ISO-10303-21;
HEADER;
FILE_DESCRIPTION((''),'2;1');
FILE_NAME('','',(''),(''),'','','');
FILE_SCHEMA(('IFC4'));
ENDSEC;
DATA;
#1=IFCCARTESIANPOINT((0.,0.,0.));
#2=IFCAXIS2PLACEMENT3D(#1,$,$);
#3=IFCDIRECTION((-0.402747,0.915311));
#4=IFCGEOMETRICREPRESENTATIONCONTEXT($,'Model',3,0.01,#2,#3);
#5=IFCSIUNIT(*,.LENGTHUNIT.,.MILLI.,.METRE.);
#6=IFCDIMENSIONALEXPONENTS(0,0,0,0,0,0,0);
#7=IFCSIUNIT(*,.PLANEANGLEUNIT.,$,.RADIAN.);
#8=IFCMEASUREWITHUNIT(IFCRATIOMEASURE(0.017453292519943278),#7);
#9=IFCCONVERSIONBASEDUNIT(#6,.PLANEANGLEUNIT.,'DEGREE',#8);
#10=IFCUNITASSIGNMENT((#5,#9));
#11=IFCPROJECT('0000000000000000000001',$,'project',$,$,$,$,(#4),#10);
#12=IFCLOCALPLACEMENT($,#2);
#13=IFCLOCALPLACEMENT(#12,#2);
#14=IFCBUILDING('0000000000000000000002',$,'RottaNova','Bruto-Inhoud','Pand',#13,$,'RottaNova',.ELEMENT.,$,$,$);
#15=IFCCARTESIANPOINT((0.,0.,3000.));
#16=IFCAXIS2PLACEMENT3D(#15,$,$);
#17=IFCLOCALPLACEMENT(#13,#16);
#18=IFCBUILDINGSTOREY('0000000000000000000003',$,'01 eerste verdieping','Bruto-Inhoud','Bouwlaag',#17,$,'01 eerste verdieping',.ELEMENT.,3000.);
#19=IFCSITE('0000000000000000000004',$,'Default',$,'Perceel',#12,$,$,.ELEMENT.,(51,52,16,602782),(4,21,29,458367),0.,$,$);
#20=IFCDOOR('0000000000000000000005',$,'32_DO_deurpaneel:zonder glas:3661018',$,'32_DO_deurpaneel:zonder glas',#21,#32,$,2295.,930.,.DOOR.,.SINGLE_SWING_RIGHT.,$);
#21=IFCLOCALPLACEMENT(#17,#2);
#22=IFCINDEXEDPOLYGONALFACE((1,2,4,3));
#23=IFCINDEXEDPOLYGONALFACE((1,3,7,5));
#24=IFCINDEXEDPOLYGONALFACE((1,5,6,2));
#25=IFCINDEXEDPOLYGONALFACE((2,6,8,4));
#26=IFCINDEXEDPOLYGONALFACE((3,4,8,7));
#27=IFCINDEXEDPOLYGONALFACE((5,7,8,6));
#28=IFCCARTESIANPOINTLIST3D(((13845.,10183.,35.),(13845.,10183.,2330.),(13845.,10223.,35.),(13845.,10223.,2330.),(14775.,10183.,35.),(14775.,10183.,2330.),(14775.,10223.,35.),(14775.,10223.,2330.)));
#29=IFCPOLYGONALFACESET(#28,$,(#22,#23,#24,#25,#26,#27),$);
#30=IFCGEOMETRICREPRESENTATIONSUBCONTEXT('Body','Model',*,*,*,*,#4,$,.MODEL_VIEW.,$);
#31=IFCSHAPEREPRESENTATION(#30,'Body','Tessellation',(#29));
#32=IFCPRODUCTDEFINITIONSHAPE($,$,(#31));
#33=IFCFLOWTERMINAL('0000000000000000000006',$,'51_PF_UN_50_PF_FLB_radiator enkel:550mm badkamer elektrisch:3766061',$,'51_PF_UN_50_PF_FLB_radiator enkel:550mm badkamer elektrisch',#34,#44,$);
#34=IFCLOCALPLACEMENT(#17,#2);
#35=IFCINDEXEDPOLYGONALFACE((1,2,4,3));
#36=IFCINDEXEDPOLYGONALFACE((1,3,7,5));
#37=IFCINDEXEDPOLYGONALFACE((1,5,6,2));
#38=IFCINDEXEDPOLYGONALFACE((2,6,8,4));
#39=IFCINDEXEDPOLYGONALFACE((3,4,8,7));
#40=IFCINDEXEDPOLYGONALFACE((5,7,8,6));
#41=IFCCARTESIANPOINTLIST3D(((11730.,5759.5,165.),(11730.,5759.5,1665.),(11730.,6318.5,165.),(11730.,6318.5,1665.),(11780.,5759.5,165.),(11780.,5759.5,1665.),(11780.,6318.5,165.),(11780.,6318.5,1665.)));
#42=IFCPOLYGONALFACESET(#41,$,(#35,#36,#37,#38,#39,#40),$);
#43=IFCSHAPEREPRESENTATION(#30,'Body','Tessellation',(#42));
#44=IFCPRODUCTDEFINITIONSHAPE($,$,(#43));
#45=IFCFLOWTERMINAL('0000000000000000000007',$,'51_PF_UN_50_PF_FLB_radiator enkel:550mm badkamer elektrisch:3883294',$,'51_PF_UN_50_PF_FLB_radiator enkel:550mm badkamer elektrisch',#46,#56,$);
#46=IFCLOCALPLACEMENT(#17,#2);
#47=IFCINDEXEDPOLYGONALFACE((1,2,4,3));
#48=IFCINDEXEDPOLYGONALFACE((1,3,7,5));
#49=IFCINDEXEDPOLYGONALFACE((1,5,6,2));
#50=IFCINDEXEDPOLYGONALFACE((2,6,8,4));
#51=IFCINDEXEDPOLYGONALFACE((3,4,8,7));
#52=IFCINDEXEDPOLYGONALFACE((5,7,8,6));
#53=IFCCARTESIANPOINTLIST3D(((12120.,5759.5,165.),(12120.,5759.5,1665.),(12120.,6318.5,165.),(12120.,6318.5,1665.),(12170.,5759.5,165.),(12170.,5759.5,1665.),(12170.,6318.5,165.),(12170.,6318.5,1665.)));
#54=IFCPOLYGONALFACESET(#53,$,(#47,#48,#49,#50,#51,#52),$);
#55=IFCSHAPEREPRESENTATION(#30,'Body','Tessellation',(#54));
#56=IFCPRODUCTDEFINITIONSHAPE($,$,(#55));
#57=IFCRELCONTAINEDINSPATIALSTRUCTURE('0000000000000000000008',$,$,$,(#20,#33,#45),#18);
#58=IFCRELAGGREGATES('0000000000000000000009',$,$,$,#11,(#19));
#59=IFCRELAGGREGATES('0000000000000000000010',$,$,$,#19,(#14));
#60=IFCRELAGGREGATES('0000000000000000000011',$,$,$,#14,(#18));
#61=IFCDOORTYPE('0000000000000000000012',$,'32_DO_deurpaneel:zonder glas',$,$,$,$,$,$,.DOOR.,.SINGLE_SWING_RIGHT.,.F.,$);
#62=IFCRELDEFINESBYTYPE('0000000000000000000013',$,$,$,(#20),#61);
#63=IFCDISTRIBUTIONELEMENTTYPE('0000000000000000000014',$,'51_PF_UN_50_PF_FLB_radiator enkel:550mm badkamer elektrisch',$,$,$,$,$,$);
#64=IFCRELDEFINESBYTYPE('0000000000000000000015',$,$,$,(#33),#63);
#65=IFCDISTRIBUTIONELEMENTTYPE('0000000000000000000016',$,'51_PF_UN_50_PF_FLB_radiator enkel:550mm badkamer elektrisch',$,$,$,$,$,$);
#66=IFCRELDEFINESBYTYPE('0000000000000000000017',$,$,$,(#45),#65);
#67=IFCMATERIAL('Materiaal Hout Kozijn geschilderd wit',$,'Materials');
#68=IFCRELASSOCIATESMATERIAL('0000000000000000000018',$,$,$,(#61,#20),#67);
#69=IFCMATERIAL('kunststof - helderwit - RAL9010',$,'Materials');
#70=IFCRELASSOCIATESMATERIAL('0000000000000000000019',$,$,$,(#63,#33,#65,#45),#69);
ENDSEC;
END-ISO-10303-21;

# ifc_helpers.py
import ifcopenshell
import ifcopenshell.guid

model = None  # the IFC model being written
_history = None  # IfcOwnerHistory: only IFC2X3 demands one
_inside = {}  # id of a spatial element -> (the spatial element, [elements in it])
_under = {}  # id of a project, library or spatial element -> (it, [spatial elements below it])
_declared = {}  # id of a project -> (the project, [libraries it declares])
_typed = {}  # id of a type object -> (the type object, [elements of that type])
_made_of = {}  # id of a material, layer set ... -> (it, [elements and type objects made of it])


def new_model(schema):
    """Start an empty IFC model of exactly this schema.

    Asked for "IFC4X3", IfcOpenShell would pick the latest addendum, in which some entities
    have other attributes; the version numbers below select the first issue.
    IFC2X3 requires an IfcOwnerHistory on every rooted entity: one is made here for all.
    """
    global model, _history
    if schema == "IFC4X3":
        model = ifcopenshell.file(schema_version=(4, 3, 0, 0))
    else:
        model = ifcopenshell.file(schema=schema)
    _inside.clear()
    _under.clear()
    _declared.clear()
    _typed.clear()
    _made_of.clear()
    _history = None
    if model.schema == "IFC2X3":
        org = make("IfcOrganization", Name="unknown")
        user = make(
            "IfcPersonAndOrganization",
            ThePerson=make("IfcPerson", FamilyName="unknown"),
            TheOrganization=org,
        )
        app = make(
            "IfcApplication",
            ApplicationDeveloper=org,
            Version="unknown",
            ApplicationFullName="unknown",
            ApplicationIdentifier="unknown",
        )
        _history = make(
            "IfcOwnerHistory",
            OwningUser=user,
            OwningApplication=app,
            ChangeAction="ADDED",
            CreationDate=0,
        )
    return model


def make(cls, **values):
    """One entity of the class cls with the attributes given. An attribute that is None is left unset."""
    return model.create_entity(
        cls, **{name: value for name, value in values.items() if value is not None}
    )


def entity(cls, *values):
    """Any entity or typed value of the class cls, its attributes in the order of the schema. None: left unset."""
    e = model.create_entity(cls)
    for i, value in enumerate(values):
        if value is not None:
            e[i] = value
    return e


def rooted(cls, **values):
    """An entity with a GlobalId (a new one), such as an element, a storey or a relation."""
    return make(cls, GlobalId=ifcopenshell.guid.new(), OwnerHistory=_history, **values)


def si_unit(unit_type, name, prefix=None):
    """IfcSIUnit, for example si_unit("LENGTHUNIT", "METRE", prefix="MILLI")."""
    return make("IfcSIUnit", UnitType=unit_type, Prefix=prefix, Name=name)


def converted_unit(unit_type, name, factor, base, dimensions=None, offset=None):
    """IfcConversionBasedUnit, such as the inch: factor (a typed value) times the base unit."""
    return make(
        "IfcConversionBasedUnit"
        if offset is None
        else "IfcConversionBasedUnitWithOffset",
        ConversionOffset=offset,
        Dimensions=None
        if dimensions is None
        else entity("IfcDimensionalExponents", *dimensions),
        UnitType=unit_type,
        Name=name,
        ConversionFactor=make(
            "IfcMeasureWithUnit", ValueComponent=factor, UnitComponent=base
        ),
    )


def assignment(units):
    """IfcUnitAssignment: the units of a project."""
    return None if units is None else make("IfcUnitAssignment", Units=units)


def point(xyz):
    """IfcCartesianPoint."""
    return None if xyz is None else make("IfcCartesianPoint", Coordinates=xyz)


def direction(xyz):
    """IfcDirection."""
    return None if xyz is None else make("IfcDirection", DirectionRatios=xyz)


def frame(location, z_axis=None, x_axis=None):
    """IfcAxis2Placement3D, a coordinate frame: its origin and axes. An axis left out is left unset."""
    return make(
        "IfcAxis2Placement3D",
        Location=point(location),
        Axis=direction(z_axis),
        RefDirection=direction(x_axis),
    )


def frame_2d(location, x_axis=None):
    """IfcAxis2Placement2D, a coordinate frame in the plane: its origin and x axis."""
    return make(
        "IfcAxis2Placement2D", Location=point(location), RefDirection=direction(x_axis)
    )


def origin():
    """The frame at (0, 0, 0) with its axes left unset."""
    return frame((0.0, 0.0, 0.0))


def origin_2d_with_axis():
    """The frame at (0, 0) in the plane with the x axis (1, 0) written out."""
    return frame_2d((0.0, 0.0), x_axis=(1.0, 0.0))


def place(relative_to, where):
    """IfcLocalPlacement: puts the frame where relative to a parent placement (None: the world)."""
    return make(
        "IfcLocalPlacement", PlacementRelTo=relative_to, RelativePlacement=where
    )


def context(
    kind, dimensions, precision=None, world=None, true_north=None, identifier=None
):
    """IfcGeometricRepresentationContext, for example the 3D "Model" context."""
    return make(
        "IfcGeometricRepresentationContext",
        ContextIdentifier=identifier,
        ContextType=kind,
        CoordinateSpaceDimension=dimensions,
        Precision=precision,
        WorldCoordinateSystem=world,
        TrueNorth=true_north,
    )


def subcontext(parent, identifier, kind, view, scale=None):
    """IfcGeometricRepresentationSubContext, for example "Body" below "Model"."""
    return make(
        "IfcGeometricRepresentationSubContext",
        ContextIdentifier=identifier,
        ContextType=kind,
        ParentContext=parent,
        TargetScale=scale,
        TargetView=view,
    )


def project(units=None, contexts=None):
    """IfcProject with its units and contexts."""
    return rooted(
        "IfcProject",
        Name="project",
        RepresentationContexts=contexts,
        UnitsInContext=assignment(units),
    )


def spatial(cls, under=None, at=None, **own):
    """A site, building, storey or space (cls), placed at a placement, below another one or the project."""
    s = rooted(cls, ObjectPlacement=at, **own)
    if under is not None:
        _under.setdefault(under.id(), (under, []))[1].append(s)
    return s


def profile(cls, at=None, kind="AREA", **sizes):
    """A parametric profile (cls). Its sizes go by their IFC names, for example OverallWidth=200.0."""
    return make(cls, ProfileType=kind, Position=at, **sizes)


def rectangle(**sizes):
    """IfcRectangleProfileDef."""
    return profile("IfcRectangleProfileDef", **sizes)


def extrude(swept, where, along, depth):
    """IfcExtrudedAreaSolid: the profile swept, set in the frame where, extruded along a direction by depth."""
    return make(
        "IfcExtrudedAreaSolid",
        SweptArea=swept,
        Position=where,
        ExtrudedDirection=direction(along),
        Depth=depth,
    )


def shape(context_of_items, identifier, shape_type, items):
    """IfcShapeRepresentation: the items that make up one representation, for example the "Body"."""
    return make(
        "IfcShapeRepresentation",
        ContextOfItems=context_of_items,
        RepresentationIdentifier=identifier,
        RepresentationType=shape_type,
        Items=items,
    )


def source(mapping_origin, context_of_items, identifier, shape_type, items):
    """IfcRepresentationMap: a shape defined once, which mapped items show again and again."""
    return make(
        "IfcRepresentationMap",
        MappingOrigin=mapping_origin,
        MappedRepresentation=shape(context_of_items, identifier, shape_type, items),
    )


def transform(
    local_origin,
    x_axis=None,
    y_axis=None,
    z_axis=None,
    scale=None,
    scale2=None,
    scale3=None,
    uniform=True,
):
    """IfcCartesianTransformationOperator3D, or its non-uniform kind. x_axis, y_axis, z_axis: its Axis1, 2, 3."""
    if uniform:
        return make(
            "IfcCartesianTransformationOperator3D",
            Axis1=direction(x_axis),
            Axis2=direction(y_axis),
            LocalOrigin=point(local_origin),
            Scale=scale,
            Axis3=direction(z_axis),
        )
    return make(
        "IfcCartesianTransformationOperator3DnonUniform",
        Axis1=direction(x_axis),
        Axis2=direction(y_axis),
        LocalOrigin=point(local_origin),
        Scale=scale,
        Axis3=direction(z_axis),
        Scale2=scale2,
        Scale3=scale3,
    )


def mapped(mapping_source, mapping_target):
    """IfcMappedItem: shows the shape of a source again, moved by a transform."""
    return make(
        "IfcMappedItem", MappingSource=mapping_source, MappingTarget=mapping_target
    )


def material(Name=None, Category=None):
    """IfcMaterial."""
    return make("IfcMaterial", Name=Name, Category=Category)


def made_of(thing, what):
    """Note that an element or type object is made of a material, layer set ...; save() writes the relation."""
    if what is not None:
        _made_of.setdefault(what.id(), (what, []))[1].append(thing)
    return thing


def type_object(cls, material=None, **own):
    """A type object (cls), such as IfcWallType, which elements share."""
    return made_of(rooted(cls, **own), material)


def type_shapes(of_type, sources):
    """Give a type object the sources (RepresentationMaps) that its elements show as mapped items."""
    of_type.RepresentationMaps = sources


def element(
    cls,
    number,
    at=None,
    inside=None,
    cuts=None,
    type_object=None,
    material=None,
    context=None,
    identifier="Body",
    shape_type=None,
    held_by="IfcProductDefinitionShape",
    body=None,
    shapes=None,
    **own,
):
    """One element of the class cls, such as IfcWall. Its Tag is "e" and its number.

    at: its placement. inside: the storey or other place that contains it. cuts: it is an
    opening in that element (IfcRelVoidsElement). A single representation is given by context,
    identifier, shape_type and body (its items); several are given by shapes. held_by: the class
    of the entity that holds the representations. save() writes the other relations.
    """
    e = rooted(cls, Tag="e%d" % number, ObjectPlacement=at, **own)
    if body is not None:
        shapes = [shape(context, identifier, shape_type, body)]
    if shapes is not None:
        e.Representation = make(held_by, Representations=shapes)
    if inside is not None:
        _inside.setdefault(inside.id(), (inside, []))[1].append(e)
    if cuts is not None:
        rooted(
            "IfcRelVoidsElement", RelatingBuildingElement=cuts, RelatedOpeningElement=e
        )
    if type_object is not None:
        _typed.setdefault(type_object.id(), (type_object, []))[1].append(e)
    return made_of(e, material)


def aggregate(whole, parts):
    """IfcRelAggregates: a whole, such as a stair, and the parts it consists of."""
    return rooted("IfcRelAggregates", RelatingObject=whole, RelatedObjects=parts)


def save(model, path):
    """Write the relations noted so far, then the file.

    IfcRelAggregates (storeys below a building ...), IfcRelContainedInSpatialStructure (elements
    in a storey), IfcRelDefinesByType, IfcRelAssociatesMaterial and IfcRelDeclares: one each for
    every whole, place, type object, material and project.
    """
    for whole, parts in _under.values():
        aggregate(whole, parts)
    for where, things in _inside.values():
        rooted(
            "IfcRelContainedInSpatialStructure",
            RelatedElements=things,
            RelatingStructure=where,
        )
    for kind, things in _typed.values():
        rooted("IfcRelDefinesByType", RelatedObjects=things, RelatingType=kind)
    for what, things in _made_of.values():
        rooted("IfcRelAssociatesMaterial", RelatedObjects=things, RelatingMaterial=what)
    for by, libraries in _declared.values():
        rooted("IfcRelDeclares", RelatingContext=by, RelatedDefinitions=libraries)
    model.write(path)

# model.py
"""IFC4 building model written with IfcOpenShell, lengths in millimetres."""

from ifc_helpers import new_model, entity, si_unit, converted_unit, direction, frame, frame_2d, origin, origin_2d_with_axis, place, context, subcontext, project, spatial, rectangle, extrude, source, transform, mapped, material, type_object, type_shapes, element, save


model = new_model("IFC4")

# Units and contexts
model_context = context("Model", 3, precision=0.01, world=origin(), true_north=direction((-0.402747, 0.915311)))
body_context = subcontext(model_context, "Body", "Model", "MODEL_VIEW")
ifc_project = project(units=[si_unit("LENGTHUNIT", "METRE", prefix="MILLI"), converted_unit("PLANEANGLEUNIT", "DEGREE", entity("IfcRatioMeasure", 0.017453292519943278), si_unit("PLANEANGLEUNIT", "RADIAN"), dimensions=[0, 0, 0, 0, 0, 0, 0])], contexts=[model_context])

# Site, building, storey
site_placement = place(None, origin())
site = spatial("IfcSite", under=ifc_project, at=site_placement, Name="Default", ObjectType="Perceel", CompositionType="ELEMENT", RefLatitude=(51, 52, 16, 602782), RefLongitude=(4, 21, 29, 458367), RefElevation=0.0)
building_placement = place(site_placement, origin())
building = spatial("IfcBuilding", under=site, at=building_placement, Name="RottaNova", Description="Bruto-Inhoud", ObjectType="Pand", LongName="RottaNova", CompositionType="ELEMENT")
storey_placement = place(building_placement, frame((0.0, 0.0, 3000.0)))
storey = spatial("IfcBuildingStorey", under=building, at=storey_placement, Name="01 eerste verdieping", Description="Bruto-Inhoud", ObjectType="Bouwlaag", LongName="01 eerste verdieping", CompositionType="ELEMENT", Elevation=3000.0)

# Door
ifc_material_1 = material(Name="Materiaal Hout Kozijn geschilderd wit", Category="Materials")
door_type = type_object("IfcDoorType", Name="32_DO_deurpaneel:zonder glas", OperationType="SINGLE_SWING_RIGHT", ParameterTakesPrecedence=False, PredefinedType="DOOR", material=ifc_material_1)
shared_shape_1 = source(origin(), body_context, "Body", "SweptSolid", [
    extrude(rectangle(XDim=2295.0, YDim=40.0, at=frame_2d((0.0, 0.0), x_axis=(1.0, 0.0))), frame((-465.0, 20.0, 1182.5), z_axis=(1.0, 0.0, 0.0), x_axis=(0.0, 0.0, 1.0)), (0.0, 0.0, 1.0), 930.0),
])
type_shapes(door_type, [shared_shape_1])
door_placement = place(storey_placement, frame((14310.0, 10223.0, 0.0), z_axis=(0.0, 0.0, 1.0), x_axis=(-1.0, 0.0, 0.0)))
element("IfcDoor", 1, at=door_placement, inside=storey, type_object=door_type, material=ifc_material_1, Name="32_DO_deurpaneel:zonder glas:3661018", ObjectType="32_DO_deurpaneel:zonder glas", OperationType="SINGLE_SWING_RIGHT", OverallHeight=2295.0, OverallWidth=930.0, PredefinedType="DOOR", context=body_context, shape_type="MappedRepresentation", body=[
    mapped(shared_shape_1, transform((0.0, 0.0, 0.0), scale=1.0)),
])

# Flow terminals
ifc_material_2 = material(Name="kunststof - helderwit - RAL9010", Category="Materials")
distribution_element_type_1 = type_object("IfcDistributionElementType", Name="51_PF_UN_50_PF_FLB_radiator enkel:550mm badkamer elektrisch", material=ifc_material_2)
shared_shape_2 = source(origin(), body_context, "Body", "SweptSolid", [
    extrude(rectangle(XDim=559.0, YDim=50.0, at=origin_2d_with_axis()), frame((279.5, 25.0, 0.0), z_axis=(0.0, 0.0, 1.0), x_axis=(-1.0, 0.0, 0.0)), (0.0, 0.0, 1.0), 1500.0),
])
type_shapes(distribution_element_type_1, [shared_shape_2])
flow_terminal_1_placement = place(storey_placement, frame((11730.0, 6318.5, 165.0), z_axis=(0.0, 0.0, 1.0), x_axis=(0.0, -1.0, 0.0)))
element("IfcFlowTerminal", 2, at=flow_terminal_1_placement, inside=storey, type_object=distribution_element_type_1, material=ifc_material_2, Name="51_PF_UN_50_PF_FLB_radiator enkel:550mm badkamer elektrisch:3766061", ObjectType="51_PF_UN_50_PF_FLB_radiator enkel:550mm badkamer elektrisch", context=body_context, shape_type="MappedRepresentation", body=[
    mapped(shared_shape_2, transform((0.0, 0.0, 0.0), scale=1.0)),
])
distribution_element_type_2 = type_object("IfcDistributionElementType", Name="51_PF_UN_50_PF_FLB_radiator enkel:550mm badkamer elektrisch", material=ifc_material_2)
shared_shape_3 = source(origin(), body_context, "Body", "SweptSolid", [
    extrude(rectangle(XDim=50.0, YDim=559.0, at=origin_2d_with_axis()), frame((279.5, 25.0, 0.0), z_axis=(0.0, 0.0, 1.0), x_axis=(0.0, 1.0, 0.0)), (0.0, 0.0, 1.0), 1500.0),
])
type_shapes(distribution_element_type_2, [shared_shape_3])
flow_terminal_2_placement = place(storey_placement, frame((12120.0, 6318.5, 165.0), z_axis=(0.0, 0.0, 1.0), x_axis=(0.0, -1.0, 0.0)))
element("IfcFlowTerminal", 3, at=flow_terminal_2_placement, inside=storey, type_object=distribution_element_type_2, material=ifc_material_2, Name="51_PF_UN_50_PF_FLB_radiator enkel:550mm badkamer elektrisch:3883294", ObjectType="51_PF_UN_50_PF_FLB_radiator enkel:550mm badkamer elektrisch", context=body_context, shape_type="MappedRepresentation", body=[
    mapped(shared_shape_3, transform((0.0, 0.0, 0.0), scale=1.0)),
])

save(model, "model.ifc")
